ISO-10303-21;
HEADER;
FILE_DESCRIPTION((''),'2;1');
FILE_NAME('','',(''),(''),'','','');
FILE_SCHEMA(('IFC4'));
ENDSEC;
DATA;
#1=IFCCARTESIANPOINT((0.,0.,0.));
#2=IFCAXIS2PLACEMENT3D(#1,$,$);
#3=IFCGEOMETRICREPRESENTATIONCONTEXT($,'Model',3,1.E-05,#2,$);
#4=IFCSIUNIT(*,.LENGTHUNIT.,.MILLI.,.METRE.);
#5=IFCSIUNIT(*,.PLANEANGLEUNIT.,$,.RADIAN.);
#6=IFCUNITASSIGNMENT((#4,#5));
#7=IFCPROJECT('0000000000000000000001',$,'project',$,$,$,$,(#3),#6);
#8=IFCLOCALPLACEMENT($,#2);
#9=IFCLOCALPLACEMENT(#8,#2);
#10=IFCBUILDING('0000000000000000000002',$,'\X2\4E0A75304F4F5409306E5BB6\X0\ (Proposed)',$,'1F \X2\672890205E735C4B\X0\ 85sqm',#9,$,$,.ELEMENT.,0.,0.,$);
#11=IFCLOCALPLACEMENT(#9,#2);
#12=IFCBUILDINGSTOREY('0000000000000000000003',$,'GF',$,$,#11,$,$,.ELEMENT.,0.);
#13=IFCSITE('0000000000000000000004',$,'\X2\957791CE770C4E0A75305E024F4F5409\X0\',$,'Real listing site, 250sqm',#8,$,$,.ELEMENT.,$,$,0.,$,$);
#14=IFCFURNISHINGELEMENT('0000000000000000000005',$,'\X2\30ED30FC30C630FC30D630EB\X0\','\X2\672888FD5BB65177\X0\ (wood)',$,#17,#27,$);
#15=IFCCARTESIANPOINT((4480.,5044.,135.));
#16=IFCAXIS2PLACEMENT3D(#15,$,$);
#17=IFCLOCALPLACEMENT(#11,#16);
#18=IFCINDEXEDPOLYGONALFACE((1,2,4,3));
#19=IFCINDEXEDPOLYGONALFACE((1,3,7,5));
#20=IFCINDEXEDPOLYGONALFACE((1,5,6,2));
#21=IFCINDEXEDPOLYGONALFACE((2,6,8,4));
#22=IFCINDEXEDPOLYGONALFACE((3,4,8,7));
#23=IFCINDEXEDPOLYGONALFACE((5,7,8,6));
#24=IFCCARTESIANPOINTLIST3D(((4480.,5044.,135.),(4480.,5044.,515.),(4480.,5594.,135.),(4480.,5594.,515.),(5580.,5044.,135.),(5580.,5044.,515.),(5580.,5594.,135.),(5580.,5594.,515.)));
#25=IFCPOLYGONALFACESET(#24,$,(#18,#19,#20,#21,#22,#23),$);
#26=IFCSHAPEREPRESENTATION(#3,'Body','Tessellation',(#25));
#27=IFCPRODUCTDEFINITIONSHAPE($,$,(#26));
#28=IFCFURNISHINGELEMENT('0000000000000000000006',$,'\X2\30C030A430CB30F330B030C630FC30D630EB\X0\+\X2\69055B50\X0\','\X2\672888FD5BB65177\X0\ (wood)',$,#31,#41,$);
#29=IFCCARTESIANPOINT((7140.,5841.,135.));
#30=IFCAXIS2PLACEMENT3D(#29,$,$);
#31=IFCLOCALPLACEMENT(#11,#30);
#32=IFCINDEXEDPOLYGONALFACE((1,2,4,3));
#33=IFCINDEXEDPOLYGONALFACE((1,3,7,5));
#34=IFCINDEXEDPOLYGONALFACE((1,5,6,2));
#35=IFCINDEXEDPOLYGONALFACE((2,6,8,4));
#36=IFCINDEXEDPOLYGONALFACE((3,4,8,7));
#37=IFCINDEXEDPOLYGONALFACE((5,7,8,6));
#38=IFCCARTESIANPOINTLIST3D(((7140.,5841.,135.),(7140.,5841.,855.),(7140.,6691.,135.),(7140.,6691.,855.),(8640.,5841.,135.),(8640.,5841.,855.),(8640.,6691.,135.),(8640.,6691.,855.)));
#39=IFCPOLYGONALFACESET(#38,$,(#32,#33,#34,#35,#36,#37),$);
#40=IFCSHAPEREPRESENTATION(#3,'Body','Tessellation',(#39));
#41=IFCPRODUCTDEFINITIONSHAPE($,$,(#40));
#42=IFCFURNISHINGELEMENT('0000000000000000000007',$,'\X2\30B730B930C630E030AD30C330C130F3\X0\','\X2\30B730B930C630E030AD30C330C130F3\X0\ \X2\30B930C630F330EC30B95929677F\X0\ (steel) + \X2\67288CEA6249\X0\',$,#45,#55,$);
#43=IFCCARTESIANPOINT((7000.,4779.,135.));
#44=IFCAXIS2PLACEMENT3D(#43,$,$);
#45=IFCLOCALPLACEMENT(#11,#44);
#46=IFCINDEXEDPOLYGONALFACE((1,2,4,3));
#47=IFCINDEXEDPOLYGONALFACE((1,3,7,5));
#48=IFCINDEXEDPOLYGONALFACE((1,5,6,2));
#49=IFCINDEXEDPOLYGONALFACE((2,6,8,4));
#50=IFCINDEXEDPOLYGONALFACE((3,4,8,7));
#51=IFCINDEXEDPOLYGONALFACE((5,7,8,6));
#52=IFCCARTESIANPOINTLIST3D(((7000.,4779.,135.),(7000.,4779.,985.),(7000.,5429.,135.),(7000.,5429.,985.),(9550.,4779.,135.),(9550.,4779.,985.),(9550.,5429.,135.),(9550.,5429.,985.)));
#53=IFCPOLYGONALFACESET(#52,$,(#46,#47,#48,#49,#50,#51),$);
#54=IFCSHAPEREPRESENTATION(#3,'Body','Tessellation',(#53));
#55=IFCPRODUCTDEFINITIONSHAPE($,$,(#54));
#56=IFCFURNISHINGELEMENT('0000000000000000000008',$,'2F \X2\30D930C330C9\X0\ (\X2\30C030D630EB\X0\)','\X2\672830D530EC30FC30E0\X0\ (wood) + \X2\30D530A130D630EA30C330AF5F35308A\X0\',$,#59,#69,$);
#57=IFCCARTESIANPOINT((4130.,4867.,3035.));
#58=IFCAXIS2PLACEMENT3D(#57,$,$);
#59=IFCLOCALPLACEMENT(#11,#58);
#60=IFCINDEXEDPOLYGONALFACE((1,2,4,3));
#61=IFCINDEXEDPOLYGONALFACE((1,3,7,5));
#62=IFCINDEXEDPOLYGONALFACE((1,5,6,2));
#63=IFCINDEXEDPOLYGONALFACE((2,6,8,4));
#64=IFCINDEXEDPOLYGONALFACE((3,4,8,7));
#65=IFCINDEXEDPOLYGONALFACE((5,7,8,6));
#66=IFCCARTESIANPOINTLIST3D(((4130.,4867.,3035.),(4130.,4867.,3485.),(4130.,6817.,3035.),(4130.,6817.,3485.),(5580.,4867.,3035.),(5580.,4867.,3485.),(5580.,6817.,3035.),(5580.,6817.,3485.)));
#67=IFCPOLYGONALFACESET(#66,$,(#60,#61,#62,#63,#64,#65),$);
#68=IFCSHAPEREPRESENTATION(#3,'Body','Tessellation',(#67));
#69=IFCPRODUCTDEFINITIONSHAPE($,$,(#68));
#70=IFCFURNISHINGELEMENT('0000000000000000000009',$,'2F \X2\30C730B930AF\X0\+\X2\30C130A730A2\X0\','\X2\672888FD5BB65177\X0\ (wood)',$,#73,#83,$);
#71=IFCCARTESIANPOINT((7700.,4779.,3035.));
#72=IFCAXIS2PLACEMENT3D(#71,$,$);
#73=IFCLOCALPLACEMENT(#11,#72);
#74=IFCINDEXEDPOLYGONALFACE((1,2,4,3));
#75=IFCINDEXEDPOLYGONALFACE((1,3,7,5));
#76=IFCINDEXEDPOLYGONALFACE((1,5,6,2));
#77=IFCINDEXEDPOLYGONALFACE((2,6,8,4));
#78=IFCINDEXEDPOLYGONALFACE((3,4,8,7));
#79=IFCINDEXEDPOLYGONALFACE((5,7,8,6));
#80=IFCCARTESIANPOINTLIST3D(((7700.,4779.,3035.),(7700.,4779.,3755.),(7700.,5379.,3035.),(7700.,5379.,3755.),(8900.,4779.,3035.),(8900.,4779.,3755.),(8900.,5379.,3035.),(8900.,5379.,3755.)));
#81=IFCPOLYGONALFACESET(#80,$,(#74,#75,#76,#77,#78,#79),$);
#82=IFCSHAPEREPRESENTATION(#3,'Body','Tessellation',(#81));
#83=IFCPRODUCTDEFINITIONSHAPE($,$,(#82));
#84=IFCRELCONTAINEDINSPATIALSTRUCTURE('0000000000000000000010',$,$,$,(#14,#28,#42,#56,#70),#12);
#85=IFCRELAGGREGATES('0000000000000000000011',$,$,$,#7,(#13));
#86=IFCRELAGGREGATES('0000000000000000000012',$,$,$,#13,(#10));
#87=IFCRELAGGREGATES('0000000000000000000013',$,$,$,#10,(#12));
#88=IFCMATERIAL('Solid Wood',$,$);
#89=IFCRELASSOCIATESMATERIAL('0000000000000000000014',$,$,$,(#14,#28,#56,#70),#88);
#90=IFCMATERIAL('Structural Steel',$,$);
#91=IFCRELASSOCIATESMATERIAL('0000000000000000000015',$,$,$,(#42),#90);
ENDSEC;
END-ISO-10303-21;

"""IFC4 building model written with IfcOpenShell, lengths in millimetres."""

from ifc_helpers import new_model, si_unit, frame, frame_2d, origin, place, context, project, spatial, rectangle, extrude, material, element, save


model = new_model("IFC4")

# Units and contexts
model_context = context("Model", 3, precision=1e-05, world=origin())
ifc_project = project(units=[si_unit("LENGTHUNIT", "METRE", prefix="MILLI"), si_unit("PLANEANGLEUNIT", "RADIAN")], contexts=[model_context])

# Site, building, storey
site_placement = place(None, origin())
site = spatial("IfcSite", under=ifc_project, at=site_placement, Name="長野県上田市住吉", ObjectType="Real listing site, 250sqm", CompositionType="ELEMENT", RefElevation=0.0)
building_placement = place(site_placement, origin())
building = spatial("IfcBuilding", under=site, at=building_placement, Name="上田住吉の家 (Proposed)", ObjectType="1F 木造平屋 85sqm", CompositionType="ELEMENT", ElevationOfRefHeight=0.0, ElevationOfTerrain=0.0)
storey_placement = place(building_placement, origin())
storey = spatial("IfcBuildingStorey", under=building, at=storey_placement, Name="GF", CompositionType="ELEMENT", Elevation=0.0)

# Shared definitions
ifc_material_1 = material(Name="Solid Wood")

# Shared definitions
ifc_material_2 = material(Name="Structural Steel")

# Furnishing elements
furnishing_1_placement = place(storey_placement, frame((4480.0, 5044.0, 135.0)))
element("IfcFurnishingElement", 1, at=furnishing_1_placement, inside=storey, material=ifc_material_1, Name="ローテーブル", Description="木製家具 (wood)", context=model_context, shape_type="SweptSolid", body=[
    extrude(rectangle(XDim=1100.0, YDim=550.0, at=frame_2d((550.0, 275.0))), frame((4480.0, 5044.0, 135.0)), (0.0, 0.0, 1.0), 380.0),
])
furnishing_2_placement = place(storey_placement, frame((7140.0, 5841.0, 135.0)))
element("IfcFurnishingElement", 2, at=furnishing_2_placement, inside=storey, material=ifc_material_1, Name="ダイニングテーブル+椅子", Description="木製家具 (wood)", context=model_context, shape_type="SweptSolid", body=[
    extrude(rectangle(XDim=1500.0, YDim=850.0, at=frame_2d((750.0, 425.0))), frame((7140.0, 5841.0, 135.0)), (0.0, 0.0, 1.0), 720.0),
])
furnishing_3_placement = place(storey_placement, frame((7000.0, 4779.0, 135.0)))
element("IfcFurnishingElement", 3, at=furnishing_3_placement, inside=storey, material=ifc_material_2, Name="システムキッチン", Description="システムキッチン ステンレス天板 (steel) + 木質扉", context=model_context, shape_type="SweptSolid", body=[
    extrude(rectangle(XDim=2550.0, YDim=650.0, at=frame_2d((1275.0, 325.0))), frame((7000.0, 4779.0, 135.0)), (0.0, 0.0, 1.0), 850.0),
])
furnishing_4_placement = place(storey_placement, frame((4130.0, 4867.0, 3035.0)))
element("IfcFurnishingElement", 4, at=furnishing_4_placement, inside=storey, material=ifc_material_1, Name="2F ベッド (ダブル)", Description="木フレーム (wood) + ファブリック張り", context=model_context, shape_type="SweptSolid", body=[
    extrude(rectangle(XDim=1450.0, YDim=1950.0, at=frame_2d((725.0, 975.0))), frame((4130.0, 4867.0, 3035.0)), (0.0, 0.0, 1.0), 450.0),
])
furnishing_5_placement = place(storey_placement, frame((7700.0, 4779.0, 3035.0)))
element("IfcFurnishingElement", 5, at=furnishing_5_placement, inside=storey, material=ifc_material_1, Name="2F デスク+チェア", Description="木製家具 (wood)", context=model_context, shape_type="SweptSolid", body=[
    extrude(rectangle(XDim=1200.0, YDim=600.0, at=frame_2d((600.0, 300.0))), frame((7700.0, 4779.0, 3035.0)), (0.0, 0.0, 1.0), 720.0),
])

save(model, "model.ifc")
